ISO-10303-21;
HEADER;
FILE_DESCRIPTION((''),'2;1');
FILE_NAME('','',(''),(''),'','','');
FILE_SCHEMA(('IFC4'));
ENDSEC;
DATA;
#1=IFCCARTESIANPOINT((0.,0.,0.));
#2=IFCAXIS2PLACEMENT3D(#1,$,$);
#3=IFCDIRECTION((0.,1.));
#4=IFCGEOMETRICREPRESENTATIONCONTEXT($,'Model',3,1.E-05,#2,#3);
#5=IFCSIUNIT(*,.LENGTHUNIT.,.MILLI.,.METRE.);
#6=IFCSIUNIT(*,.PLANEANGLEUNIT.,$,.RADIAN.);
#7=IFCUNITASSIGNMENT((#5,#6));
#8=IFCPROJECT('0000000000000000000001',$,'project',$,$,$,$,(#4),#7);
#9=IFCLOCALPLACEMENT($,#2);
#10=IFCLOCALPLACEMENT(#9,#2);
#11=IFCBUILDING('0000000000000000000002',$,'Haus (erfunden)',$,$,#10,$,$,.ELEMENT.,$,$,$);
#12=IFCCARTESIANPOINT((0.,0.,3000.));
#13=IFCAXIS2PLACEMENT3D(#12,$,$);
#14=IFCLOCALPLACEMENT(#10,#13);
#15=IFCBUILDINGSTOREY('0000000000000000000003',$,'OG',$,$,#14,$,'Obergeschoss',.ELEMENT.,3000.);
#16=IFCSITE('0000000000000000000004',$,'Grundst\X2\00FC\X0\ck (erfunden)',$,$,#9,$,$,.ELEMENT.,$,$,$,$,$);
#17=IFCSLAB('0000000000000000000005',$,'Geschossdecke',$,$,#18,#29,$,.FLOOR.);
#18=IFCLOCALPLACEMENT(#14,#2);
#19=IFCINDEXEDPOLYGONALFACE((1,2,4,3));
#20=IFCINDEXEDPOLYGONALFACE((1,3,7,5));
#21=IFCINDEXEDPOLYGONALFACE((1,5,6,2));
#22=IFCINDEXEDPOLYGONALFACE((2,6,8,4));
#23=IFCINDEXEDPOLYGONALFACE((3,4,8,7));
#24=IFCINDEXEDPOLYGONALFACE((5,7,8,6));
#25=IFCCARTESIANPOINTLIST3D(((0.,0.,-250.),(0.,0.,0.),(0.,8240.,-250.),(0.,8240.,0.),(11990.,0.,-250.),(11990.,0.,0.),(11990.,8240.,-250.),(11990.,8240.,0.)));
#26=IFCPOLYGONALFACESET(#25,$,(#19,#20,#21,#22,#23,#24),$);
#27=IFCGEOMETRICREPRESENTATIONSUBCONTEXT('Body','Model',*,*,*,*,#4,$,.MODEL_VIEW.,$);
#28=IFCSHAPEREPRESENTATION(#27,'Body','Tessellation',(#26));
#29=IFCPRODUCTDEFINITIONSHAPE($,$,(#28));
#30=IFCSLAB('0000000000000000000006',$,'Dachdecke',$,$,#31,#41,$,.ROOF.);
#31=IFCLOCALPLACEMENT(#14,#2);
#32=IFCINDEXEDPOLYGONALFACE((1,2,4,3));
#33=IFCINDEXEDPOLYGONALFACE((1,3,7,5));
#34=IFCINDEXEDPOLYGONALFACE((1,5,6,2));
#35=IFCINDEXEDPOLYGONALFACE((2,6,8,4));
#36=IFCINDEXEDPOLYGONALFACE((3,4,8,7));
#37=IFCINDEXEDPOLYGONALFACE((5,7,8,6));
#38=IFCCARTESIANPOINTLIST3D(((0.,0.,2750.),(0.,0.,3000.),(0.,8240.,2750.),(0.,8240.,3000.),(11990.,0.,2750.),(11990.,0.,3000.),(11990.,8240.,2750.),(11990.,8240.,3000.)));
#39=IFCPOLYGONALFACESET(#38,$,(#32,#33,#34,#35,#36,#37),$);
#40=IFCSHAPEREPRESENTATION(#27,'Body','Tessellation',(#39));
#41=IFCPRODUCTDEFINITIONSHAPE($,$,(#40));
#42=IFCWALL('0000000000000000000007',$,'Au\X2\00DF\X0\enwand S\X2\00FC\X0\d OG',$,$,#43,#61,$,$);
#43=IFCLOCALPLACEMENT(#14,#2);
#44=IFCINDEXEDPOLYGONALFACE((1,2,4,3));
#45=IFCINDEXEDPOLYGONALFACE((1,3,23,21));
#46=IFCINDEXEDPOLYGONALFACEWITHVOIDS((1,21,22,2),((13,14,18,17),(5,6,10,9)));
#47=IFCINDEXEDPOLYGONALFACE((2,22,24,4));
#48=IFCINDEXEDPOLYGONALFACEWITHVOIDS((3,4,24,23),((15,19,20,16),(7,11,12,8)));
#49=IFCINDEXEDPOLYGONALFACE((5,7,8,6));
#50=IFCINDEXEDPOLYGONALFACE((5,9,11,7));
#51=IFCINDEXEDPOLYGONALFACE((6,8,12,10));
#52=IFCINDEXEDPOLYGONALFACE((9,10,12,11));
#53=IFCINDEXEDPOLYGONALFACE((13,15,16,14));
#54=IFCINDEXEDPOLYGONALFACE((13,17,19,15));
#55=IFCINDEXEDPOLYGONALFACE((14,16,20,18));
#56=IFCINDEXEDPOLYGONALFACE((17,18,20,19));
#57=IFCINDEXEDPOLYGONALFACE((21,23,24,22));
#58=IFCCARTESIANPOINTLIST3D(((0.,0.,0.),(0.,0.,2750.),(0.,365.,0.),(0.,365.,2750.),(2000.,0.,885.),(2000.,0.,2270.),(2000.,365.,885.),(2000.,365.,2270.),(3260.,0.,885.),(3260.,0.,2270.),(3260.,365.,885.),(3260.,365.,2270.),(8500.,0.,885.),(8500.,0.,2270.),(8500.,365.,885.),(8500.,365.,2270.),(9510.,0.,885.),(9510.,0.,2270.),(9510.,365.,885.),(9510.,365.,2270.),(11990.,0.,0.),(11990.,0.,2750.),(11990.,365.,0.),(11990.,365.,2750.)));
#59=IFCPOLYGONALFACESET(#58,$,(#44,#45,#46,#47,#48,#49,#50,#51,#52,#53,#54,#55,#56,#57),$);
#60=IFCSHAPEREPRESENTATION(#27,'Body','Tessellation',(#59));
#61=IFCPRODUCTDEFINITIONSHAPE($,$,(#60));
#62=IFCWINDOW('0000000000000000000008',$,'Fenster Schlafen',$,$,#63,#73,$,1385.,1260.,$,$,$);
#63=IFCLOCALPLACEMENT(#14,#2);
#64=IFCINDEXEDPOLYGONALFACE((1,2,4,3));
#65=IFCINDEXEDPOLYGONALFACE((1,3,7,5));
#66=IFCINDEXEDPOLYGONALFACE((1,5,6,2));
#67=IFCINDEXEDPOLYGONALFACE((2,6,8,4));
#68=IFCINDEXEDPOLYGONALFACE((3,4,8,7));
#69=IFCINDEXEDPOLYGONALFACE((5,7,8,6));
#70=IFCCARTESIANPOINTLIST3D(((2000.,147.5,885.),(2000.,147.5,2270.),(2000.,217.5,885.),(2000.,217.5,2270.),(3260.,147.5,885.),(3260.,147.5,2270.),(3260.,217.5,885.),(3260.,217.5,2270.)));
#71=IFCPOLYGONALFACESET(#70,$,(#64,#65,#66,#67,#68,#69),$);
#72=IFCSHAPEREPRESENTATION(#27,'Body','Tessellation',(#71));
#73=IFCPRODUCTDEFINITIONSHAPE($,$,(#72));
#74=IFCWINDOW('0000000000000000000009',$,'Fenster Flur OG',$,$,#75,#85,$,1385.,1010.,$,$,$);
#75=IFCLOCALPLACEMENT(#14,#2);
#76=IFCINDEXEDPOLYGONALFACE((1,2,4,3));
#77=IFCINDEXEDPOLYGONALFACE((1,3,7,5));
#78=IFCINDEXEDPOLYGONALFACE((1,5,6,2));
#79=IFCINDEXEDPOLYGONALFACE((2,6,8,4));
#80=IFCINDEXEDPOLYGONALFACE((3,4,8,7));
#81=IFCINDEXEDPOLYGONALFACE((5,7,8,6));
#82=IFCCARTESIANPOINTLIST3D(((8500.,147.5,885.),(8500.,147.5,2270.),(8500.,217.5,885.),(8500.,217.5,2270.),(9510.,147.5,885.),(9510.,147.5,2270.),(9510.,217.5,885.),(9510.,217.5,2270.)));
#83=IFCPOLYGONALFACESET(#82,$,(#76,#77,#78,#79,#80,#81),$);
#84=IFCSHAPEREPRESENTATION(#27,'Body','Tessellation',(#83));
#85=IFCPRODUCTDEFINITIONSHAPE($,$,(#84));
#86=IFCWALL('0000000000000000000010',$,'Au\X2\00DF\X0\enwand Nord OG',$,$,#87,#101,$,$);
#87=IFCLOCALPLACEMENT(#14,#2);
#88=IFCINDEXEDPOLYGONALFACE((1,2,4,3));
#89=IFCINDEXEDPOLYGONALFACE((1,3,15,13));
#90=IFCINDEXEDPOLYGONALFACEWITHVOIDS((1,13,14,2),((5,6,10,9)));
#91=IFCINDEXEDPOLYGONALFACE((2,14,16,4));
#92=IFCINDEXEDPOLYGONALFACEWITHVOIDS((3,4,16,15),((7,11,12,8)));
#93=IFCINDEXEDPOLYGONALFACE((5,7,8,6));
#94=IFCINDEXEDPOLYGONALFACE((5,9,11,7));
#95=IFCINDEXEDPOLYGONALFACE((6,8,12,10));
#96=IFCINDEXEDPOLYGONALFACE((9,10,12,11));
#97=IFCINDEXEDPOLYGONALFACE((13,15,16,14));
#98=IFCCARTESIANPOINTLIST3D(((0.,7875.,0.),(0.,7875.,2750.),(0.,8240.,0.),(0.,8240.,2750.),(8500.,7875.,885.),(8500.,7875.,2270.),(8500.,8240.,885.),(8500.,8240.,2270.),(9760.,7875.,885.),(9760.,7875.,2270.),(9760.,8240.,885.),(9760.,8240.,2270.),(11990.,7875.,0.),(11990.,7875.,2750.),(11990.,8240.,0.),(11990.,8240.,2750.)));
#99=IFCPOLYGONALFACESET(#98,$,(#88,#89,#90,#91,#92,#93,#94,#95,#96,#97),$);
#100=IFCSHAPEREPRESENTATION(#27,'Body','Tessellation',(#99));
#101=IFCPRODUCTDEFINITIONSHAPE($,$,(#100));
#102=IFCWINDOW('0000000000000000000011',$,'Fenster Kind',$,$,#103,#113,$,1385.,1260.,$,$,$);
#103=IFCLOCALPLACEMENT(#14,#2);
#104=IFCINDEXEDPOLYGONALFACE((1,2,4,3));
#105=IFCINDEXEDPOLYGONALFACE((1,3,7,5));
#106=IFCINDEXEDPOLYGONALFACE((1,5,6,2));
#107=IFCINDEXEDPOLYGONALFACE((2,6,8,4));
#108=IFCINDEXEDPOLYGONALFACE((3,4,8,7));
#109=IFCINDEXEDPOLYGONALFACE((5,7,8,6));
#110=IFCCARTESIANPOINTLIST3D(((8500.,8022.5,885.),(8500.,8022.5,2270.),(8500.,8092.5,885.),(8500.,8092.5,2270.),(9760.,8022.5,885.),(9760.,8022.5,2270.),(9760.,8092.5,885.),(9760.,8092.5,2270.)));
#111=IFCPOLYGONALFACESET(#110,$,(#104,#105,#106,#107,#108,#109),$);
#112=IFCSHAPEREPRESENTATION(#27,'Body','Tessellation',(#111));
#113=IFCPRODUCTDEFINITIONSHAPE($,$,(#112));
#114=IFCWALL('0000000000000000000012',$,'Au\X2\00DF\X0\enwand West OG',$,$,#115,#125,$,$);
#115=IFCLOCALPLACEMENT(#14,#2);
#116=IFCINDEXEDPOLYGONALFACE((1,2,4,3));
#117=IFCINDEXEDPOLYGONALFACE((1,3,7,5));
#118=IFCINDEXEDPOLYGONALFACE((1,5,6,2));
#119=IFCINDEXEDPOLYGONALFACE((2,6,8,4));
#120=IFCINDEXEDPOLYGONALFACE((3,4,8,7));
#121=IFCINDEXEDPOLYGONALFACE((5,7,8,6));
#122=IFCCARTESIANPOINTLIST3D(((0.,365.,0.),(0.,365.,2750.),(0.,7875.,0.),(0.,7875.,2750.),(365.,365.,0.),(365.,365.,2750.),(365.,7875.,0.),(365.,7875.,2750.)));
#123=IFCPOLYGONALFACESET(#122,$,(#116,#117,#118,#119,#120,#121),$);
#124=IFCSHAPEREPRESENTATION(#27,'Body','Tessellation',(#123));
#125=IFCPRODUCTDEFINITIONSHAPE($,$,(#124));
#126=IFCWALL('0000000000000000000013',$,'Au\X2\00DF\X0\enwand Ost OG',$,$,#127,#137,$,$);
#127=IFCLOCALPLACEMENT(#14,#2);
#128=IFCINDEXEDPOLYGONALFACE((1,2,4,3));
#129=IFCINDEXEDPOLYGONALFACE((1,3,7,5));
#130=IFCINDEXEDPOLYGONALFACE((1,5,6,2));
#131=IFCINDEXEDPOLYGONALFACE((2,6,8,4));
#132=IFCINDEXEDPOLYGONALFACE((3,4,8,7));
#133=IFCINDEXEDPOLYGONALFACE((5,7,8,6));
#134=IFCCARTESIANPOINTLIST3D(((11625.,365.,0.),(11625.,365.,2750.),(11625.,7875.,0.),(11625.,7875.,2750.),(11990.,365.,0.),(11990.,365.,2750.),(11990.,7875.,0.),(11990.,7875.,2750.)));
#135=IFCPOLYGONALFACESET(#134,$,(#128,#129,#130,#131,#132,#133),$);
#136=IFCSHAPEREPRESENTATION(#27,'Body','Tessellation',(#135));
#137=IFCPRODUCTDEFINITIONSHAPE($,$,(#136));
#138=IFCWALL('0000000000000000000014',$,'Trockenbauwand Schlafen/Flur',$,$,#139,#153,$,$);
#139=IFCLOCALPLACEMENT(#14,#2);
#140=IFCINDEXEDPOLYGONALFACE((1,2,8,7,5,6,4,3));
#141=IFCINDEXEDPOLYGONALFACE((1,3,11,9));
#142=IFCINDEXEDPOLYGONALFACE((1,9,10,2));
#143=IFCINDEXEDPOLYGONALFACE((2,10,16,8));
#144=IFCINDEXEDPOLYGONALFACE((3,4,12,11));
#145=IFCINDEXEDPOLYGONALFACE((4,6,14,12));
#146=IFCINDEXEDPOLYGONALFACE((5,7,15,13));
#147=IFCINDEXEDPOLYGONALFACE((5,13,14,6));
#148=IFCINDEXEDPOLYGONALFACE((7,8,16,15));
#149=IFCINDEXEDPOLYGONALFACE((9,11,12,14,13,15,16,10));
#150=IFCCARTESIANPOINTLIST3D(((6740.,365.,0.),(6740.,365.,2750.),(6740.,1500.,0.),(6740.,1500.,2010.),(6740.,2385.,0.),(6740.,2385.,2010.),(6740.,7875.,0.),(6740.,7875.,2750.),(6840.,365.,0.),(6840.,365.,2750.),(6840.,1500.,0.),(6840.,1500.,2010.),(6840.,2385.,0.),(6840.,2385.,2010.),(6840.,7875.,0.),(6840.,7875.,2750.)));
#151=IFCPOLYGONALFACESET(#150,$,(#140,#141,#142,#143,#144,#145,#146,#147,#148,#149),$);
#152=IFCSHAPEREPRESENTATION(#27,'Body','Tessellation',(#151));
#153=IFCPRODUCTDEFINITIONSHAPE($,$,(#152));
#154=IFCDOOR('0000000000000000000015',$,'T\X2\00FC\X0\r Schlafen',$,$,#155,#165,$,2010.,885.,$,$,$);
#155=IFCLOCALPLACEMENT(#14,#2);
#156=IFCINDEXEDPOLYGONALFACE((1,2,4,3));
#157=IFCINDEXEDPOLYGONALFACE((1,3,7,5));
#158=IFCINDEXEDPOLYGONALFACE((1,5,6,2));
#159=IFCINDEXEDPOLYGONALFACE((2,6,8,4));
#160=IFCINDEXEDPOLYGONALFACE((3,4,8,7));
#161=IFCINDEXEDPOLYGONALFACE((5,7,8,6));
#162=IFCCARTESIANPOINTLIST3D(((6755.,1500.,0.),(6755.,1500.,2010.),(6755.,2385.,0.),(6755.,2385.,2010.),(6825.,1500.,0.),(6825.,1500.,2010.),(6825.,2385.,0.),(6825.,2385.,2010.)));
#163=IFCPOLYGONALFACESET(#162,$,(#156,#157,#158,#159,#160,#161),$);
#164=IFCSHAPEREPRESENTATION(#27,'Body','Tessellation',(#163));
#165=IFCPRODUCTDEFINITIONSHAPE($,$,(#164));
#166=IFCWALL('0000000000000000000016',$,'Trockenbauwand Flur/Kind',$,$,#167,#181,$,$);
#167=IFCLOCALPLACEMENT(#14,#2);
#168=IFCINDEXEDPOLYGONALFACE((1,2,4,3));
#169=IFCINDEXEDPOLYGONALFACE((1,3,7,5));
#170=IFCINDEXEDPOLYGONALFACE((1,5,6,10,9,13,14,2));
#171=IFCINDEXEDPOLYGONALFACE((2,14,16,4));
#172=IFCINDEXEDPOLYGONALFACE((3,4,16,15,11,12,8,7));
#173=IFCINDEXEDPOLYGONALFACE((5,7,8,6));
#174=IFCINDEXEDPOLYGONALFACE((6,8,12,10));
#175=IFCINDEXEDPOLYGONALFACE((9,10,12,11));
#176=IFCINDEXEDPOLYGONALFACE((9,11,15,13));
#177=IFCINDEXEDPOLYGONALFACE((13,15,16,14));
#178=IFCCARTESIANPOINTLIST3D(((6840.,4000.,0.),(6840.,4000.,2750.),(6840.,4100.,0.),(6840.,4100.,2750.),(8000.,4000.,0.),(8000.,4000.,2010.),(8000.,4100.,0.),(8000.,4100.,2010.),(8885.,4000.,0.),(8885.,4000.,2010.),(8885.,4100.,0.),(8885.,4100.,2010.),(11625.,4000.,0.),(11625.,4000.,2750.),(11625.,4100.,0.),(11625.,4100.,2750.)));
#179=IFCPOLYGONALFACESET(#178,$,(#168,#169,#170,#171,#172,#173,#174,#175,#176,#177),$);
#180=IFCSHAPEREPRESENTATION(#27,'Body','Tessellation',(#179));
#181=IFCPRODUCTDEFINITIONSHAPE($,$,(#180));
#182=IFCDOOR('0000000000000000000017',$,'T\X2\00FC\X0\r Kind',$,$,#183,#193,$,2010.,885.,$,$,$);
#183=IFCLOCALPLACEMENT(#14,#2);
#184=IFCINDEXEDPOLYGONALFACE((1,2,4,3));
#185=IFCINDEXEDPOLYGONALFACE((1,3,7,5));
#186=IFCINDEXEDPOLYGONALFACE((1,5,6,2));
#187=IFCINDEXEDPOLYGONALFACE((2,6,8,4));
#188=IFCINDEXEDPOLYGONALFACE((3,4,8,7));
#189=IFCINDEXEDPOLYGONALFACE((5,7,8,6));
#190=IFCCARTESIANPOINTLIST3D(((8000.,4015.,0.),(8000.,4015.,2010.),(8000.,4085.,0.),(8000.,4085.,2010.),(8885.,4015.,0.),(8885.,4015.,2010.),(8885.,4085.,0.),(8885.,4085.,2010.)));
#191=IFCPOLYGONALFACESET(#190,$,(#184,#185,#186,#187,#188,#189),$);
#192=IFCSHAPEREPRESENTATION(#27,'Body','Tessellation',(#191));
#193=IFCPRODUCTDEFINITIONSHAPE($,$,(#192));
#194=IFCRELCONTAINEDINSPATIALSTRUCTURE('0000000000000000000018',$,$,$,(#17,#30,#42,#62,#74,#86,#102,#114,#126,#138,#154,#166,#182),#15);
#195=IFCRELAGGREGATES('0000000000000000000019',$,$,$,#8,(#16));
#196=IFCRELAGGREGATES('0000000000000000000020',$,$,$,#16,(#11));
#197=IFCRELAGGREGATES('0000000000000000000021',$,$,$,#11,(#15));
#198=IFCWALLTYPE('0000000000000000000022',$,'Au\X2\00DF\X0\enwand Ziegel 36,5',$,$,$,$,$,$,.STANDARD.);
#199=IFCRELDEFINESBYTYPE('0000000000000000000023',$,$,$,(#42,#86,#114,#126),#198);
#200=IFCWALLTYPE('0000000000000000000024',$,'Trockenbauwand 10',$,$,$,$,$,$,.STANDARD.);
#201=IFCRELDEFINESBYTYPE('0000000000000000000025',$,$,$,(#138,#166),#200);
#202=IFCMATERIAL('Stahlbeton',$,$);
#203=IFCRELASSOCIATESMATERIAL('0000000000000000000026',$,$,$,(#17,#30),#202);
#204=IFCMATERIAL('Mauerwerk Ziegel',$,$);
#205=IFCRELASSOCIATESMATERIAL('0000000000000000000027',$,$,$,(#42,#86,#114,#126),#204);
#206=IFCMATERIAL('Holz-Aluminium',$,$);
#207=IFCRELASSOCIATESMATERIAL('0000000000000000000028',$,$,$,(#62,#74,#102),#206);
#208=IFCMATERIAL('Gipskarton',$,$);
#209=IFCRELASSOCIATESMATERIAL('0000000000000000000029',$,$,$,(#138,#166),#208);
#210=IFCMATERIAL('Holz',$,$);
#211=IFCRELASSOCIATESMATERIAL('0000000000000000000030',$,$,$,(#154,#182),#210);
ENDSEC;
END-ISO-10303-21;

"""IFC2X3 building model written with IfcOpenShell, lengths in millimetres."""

from ifc_helpers import new_model, si_unit, direction, frame, frame_2d, origin, place, context, subcontext, project, spatial, rectangle, extrude, material, type_object, element, fill, save


model = new_model("IFC2X3")

# Units and contexts
model_context = context("Model", 3, precision=1e-05, world=origin(), true_north=direction((0.0, 1.0)))
body_context = subcontext(model_context, "Body", "Model", "MODEL_VIEW")
ifc_project = project(units=[si_unit("LENGTHUNIT", "METRE", prefix="MILLI"), si_unit("PLANEANGLEUNIT", "RADIAN")], contexts=[model_context])

# Site, building, storey
site_placement = place(None, origin())
site = spatial("IfcSite", under=ifc_project, at=site_placement, Name="Grundstück (erfunden)", CompositionType="ELEMENT")
building_placement = place(site_placement, origin())
building = spatial("IfcBuilding", under=site, at=building_placement, Name="Haus (erfunden)", CompositionType="ELEMENT")
storey_placement = place(building_placement, frame((0.0, 0.0, 3000.0)))
storey = spatial("IfcBuildingStorey", under=building, at=storey_placement, Name="OG", LongName="Obergeschoss", CompositionType="ELEMENT", Elevation=3000.0)

# Slabs
ifc_material_1 = material(Name="Stahlbeton")
slab_1_placement = place(storey_placement, frame((0.0, 0.0, -250.0)))
element("IfcSlab", 1, at=slab_1_placement, inside=storey, material=ifc_material_1, Name="Geschossdecke", PredefinedType="FLOOR", context=body_context, shape_type="SweptSolid", body=[
    extrude(rectangle(XDim=11990.0, YDim=8240.0, at=frame_2d((5995.0, 4120.0))), origin(), (0.0, 0.0, 1.0), 250.0),
])
slab_2_placement = place(storey_placement, frame((0.0, 0.0, 2750.0)))
element("IfcSlab", 2, at=slab_2_placement, inside=storey, material=ifc_material_1, Name="Dachdecke", PredefinedType="ROOF", context=body_context, shape_type="SweptSolid", body=[
    extrude(rectangle(XDim=11990.0, YDim=8240.0, at=frame_2d((5995.0, 4120.0))), origin(), (0.0, 0.0, 1.0), 250.0),
])

# Wall, openings, windows
ifc_material_2 = material(Name="Mauerwerk Ziegel")
wall_type_1 = type_object("IfcWallType", Name="Außenwand Ziegel 36,5", PredefinedType="STANDARD")
wall_1_placement = place(storey_placement, origin())
wall_1 = element("IfcWall", 3, at=wall_1_placement, inside=storey, type_object=wall_type_1, material=ifc_material_2, Name="Außenwand Süd OG", context=body_context, shape_type="SweptSolid", body=[
    extrude(rectangle(XDim=11990.0, YDim=365.0, at=frame_2d((5995.0, 182.5))), origin(), (0.0, 0.0, 1.0), 2750.0),
])
opening_1_placement = place(wall_1_placement, frame((2000.0, -50.0, 885.0)))
opening_1 = element("IfcOpeningElement", 4, at=opening_1_placement, cuts=wall_1, context=body_context, shape_type="SweptSolid", body=[
    extrude(rectangle(XDim=1260.0, YDim=465.0, at=frame_2d((630.0, 232.5))), origin(), (0.0, 0.0, 1.0), 1385.0),
])
opening_2_placement = place(wall_1_placement, frame((8500.0, -50.0, 885.0)))
opening_2 = element("IfcOpeningElement", 5, at=opening_2_placement, cuts=wall_1, context=body_context, shape_type="SweptSolid", body=[
    extrude(rectangle(XDim=1010.0, YDim=465.0, at=frame_2d((505.0, 232.5))), origin(), (0.0, 0.0, 1.0), 1385.0),
])
ifc_material_3 = material(Name="Holz-Aluminium")
window_1_placement = place(opening_1_placement, frame((0.0, 197.5, 0.0)))
window_1 = element("IfcWindow", 6, at=window_1_placement, inside=storey, material=ifc_material_3, Name="Fenster Schlafen", OverallHeight=1385.0, OverallWidth=1260.0, context=body_context, shape_type="SweptSolid", body=[
    extrude(rectangle(XDim=1260.0, YDim=70.0, at=frame_2d((630.0, 35.0))), origin(), (0.0, 0.0, 1.0), 1385.0),
])
fill(opening_1, window_1)
window_2_placement = place(opening_2_placement, frame((0.0, 197.5, 0.0)))
window_2 = element("IfcWindow", 7, at=window_2_placement, inside=storey, material=ifc_material_3, Name="Fenster Flur OG", OverallHeight=1385.0, OverallWidth=1010.0, context=body_context, shape_type="SweptSolid", body=[
    extrude(rectangle(XDim=1010.0, YDim=70.0, at=frame_2d((505.0, 35.0))), origin(), (0.0, 0.0, 1.0), 1385.0),
])
fill(opening_2, window_2)

# Wall, opening, window
wall_2_placement = place(storey_placement, frame((0.0, 7875.0, 0.0)))
wall_2 = element("IfcWall", 8, at=wall_2_placement, inside=storey, type_object=wall_type_1, material=ifc_material_2, Name="Außenwand Nord OG", context=body_context, shape_type="SweptSolid", body=[
    extrude(rectangle(XDim=11990.0, YDim=365.0, at=frame_2d((5995.0, 182.5))), origin(), (0.0, 0.0, 1.0), 2750.0),
])
opening_3_placement = place(wall_2_placement, frame((8500.0, -50.0, 885.0)))
opening_3 = element("IfcOpeningElement", 9, at=opening_3_placement, cuts=wall_2, context=body_context, shape_type="SweptSolid", body=[
    extrude(rectangle(XDim=1260.0, YDim=465.0, at=frame_2d((630.0, 232.5))), origin(), (0.0, 0.0, 1.0), 1385.0),
])
window_3_placement = place(opening_3_placement, frame((0.0, 197.5, 0.0)))
window_3 = element("IfcWindow", 10, at=window_3_placement, inside=storey, material=ifc_material_3, Name="Fenster Kind", OverallHeight=1385.0, OverallWidth=1260.0, context=body_context, shape_type="SweptSolid", body=[
    extrude(rectangle(XDim=1260.0, YDim=70.0, at=frame_2d((630.0, 35.0))), origin(), (0.0, 0.0, 1.0), 1385.0),
])
fill(opening_3, window_3)

# Walls
for number, where, name in (
    (11, (0.0, 365.0, 0.0), "Außenwand West OG"),
    (12, (11625.0, 365.0, 0.0), "Außenwand Ost OG"),
):
    element("IfcWall", number, at=place(storey_placement, frame(where)), inside=storey, type_object=wall_type_1, material=ifc_material_2, Name=name, context=body_context, shape_type="SweptSolid", body=[
        extrude(rectangle(XDim=365.0, YDim=7510.0, at=frame_2d((182.5, 3755.0))), origin(), (0.0, 0.0, 1.0), 2750.0),
    ])

# Walls, openings, doors
ifc_material_4 = material(Name="Gipskarton")
wall_type_2 = type_object("IfcWallType", Name="Trockenbauwand 10", PredefinedType="STANDARD")
wall_3_placement = place(storey_placement, frame((6740.0, 365.0, 0.0)))
wall_3 = element("IfcWall", 13, at=wall_3_placement, inside=storey, type_object=wall_type_2, material=ifc_material_4, Name="Trockenbauwand Schlafen/Flur", context=body_context, shape_type="SweptSolid", body=[
    extrude(rectangle(XDim=100.0, YDim=7510.0, at=frame_2d((50.0, 3755.0))), origin(), (0.0, 0.0, 1.0), 2750.0),
])
opening_4_placement = place(wall_3_placement, frame((-50.0, 1135.0, 0.0)))
opening_4 = element("IfcOpeningElement", 14, at=opening_4_placement, cuts=wall_3, context=body_context, shape_type="SweptSolid", body=[
    extrude(rectangle(XDim=200.0, YDim=885.0, at=frame_2d((100.0, 442.5))), origin(), (0.0, 0.0, 1.0), 2010.0),
])
ifc_material_5 = material(Name="Holz")
door_1_placement = place(opening_4_placement, frame((65.0, 0.0, 0.0)))
door_1 = element("IfcDoor", 15, at=door_1_placement, inside=storey, material=ifc_material_5, Name="Tür Schlafen", OverallHeight=2010.0, OverallWidth=885.0, context=body_context, shape_type="SweptSolid", body=[
    extrude(rectangle(XDim=70.0, YDim=885.0, at=frame_2d((35.0, 442.5))), origin(), (0.0, 0.0, 1.0), 2010.0),
])
fill(opening_4, door_1)
wall_4_placement = place(storey_placement, frame((6840.0, 4000.0, 0.0)))
wall_4 = element("IfcWall", 16, at=wall_4_placement, inside=storey, type_object=wall_type_2, material=ifc_material_4, Name="Trockenbauwand Flur/Kind", context=body_context, shape_type="SweptSolid", body=[
    extrude(rectangle(XDim=4785.0, YDim=100.0, at=frame_2d((2392.5, 50.0))), origin(), (0.0, 0.0, 1.0), 2750.0),
])
opening_5_placement = place(wall_4_placement, frame((1160.0, -50.0, 0.0)))
opening_5 = element("IfcOpeningElement", 17, at=opening_5_placement, cuts=wall_4, context=body_context, shape_type="SweptSolid", body=[
    extrude(rectangle(XDim=885.0, YDim=200.0, at=frame_2d((442.5, 100.0))), origin(), (0.0, 0.0, 1.0), 2010.0),
])
door_2_placement = place(opening_5_placement, frame((0.0, 65.0, 0.0)))
door_2 = element("IfcDoor", 18, at=door_2_placement, inside=storey, material=ifc_material_5, Name="Tür Kind", OverallHeight=2010.0, OverallWidth=885.0, context=body_context, shape_type="SweptSolid", body=[
    extrude(rectangle(XDim=885.0, YDim=70.0, at=frame_2d((442.5, 35.0))), origin(), (0.0, 0.0, 1.0), 2010.0),
])
fill(opening_5, door_2)

save(model, "model.ifc")
